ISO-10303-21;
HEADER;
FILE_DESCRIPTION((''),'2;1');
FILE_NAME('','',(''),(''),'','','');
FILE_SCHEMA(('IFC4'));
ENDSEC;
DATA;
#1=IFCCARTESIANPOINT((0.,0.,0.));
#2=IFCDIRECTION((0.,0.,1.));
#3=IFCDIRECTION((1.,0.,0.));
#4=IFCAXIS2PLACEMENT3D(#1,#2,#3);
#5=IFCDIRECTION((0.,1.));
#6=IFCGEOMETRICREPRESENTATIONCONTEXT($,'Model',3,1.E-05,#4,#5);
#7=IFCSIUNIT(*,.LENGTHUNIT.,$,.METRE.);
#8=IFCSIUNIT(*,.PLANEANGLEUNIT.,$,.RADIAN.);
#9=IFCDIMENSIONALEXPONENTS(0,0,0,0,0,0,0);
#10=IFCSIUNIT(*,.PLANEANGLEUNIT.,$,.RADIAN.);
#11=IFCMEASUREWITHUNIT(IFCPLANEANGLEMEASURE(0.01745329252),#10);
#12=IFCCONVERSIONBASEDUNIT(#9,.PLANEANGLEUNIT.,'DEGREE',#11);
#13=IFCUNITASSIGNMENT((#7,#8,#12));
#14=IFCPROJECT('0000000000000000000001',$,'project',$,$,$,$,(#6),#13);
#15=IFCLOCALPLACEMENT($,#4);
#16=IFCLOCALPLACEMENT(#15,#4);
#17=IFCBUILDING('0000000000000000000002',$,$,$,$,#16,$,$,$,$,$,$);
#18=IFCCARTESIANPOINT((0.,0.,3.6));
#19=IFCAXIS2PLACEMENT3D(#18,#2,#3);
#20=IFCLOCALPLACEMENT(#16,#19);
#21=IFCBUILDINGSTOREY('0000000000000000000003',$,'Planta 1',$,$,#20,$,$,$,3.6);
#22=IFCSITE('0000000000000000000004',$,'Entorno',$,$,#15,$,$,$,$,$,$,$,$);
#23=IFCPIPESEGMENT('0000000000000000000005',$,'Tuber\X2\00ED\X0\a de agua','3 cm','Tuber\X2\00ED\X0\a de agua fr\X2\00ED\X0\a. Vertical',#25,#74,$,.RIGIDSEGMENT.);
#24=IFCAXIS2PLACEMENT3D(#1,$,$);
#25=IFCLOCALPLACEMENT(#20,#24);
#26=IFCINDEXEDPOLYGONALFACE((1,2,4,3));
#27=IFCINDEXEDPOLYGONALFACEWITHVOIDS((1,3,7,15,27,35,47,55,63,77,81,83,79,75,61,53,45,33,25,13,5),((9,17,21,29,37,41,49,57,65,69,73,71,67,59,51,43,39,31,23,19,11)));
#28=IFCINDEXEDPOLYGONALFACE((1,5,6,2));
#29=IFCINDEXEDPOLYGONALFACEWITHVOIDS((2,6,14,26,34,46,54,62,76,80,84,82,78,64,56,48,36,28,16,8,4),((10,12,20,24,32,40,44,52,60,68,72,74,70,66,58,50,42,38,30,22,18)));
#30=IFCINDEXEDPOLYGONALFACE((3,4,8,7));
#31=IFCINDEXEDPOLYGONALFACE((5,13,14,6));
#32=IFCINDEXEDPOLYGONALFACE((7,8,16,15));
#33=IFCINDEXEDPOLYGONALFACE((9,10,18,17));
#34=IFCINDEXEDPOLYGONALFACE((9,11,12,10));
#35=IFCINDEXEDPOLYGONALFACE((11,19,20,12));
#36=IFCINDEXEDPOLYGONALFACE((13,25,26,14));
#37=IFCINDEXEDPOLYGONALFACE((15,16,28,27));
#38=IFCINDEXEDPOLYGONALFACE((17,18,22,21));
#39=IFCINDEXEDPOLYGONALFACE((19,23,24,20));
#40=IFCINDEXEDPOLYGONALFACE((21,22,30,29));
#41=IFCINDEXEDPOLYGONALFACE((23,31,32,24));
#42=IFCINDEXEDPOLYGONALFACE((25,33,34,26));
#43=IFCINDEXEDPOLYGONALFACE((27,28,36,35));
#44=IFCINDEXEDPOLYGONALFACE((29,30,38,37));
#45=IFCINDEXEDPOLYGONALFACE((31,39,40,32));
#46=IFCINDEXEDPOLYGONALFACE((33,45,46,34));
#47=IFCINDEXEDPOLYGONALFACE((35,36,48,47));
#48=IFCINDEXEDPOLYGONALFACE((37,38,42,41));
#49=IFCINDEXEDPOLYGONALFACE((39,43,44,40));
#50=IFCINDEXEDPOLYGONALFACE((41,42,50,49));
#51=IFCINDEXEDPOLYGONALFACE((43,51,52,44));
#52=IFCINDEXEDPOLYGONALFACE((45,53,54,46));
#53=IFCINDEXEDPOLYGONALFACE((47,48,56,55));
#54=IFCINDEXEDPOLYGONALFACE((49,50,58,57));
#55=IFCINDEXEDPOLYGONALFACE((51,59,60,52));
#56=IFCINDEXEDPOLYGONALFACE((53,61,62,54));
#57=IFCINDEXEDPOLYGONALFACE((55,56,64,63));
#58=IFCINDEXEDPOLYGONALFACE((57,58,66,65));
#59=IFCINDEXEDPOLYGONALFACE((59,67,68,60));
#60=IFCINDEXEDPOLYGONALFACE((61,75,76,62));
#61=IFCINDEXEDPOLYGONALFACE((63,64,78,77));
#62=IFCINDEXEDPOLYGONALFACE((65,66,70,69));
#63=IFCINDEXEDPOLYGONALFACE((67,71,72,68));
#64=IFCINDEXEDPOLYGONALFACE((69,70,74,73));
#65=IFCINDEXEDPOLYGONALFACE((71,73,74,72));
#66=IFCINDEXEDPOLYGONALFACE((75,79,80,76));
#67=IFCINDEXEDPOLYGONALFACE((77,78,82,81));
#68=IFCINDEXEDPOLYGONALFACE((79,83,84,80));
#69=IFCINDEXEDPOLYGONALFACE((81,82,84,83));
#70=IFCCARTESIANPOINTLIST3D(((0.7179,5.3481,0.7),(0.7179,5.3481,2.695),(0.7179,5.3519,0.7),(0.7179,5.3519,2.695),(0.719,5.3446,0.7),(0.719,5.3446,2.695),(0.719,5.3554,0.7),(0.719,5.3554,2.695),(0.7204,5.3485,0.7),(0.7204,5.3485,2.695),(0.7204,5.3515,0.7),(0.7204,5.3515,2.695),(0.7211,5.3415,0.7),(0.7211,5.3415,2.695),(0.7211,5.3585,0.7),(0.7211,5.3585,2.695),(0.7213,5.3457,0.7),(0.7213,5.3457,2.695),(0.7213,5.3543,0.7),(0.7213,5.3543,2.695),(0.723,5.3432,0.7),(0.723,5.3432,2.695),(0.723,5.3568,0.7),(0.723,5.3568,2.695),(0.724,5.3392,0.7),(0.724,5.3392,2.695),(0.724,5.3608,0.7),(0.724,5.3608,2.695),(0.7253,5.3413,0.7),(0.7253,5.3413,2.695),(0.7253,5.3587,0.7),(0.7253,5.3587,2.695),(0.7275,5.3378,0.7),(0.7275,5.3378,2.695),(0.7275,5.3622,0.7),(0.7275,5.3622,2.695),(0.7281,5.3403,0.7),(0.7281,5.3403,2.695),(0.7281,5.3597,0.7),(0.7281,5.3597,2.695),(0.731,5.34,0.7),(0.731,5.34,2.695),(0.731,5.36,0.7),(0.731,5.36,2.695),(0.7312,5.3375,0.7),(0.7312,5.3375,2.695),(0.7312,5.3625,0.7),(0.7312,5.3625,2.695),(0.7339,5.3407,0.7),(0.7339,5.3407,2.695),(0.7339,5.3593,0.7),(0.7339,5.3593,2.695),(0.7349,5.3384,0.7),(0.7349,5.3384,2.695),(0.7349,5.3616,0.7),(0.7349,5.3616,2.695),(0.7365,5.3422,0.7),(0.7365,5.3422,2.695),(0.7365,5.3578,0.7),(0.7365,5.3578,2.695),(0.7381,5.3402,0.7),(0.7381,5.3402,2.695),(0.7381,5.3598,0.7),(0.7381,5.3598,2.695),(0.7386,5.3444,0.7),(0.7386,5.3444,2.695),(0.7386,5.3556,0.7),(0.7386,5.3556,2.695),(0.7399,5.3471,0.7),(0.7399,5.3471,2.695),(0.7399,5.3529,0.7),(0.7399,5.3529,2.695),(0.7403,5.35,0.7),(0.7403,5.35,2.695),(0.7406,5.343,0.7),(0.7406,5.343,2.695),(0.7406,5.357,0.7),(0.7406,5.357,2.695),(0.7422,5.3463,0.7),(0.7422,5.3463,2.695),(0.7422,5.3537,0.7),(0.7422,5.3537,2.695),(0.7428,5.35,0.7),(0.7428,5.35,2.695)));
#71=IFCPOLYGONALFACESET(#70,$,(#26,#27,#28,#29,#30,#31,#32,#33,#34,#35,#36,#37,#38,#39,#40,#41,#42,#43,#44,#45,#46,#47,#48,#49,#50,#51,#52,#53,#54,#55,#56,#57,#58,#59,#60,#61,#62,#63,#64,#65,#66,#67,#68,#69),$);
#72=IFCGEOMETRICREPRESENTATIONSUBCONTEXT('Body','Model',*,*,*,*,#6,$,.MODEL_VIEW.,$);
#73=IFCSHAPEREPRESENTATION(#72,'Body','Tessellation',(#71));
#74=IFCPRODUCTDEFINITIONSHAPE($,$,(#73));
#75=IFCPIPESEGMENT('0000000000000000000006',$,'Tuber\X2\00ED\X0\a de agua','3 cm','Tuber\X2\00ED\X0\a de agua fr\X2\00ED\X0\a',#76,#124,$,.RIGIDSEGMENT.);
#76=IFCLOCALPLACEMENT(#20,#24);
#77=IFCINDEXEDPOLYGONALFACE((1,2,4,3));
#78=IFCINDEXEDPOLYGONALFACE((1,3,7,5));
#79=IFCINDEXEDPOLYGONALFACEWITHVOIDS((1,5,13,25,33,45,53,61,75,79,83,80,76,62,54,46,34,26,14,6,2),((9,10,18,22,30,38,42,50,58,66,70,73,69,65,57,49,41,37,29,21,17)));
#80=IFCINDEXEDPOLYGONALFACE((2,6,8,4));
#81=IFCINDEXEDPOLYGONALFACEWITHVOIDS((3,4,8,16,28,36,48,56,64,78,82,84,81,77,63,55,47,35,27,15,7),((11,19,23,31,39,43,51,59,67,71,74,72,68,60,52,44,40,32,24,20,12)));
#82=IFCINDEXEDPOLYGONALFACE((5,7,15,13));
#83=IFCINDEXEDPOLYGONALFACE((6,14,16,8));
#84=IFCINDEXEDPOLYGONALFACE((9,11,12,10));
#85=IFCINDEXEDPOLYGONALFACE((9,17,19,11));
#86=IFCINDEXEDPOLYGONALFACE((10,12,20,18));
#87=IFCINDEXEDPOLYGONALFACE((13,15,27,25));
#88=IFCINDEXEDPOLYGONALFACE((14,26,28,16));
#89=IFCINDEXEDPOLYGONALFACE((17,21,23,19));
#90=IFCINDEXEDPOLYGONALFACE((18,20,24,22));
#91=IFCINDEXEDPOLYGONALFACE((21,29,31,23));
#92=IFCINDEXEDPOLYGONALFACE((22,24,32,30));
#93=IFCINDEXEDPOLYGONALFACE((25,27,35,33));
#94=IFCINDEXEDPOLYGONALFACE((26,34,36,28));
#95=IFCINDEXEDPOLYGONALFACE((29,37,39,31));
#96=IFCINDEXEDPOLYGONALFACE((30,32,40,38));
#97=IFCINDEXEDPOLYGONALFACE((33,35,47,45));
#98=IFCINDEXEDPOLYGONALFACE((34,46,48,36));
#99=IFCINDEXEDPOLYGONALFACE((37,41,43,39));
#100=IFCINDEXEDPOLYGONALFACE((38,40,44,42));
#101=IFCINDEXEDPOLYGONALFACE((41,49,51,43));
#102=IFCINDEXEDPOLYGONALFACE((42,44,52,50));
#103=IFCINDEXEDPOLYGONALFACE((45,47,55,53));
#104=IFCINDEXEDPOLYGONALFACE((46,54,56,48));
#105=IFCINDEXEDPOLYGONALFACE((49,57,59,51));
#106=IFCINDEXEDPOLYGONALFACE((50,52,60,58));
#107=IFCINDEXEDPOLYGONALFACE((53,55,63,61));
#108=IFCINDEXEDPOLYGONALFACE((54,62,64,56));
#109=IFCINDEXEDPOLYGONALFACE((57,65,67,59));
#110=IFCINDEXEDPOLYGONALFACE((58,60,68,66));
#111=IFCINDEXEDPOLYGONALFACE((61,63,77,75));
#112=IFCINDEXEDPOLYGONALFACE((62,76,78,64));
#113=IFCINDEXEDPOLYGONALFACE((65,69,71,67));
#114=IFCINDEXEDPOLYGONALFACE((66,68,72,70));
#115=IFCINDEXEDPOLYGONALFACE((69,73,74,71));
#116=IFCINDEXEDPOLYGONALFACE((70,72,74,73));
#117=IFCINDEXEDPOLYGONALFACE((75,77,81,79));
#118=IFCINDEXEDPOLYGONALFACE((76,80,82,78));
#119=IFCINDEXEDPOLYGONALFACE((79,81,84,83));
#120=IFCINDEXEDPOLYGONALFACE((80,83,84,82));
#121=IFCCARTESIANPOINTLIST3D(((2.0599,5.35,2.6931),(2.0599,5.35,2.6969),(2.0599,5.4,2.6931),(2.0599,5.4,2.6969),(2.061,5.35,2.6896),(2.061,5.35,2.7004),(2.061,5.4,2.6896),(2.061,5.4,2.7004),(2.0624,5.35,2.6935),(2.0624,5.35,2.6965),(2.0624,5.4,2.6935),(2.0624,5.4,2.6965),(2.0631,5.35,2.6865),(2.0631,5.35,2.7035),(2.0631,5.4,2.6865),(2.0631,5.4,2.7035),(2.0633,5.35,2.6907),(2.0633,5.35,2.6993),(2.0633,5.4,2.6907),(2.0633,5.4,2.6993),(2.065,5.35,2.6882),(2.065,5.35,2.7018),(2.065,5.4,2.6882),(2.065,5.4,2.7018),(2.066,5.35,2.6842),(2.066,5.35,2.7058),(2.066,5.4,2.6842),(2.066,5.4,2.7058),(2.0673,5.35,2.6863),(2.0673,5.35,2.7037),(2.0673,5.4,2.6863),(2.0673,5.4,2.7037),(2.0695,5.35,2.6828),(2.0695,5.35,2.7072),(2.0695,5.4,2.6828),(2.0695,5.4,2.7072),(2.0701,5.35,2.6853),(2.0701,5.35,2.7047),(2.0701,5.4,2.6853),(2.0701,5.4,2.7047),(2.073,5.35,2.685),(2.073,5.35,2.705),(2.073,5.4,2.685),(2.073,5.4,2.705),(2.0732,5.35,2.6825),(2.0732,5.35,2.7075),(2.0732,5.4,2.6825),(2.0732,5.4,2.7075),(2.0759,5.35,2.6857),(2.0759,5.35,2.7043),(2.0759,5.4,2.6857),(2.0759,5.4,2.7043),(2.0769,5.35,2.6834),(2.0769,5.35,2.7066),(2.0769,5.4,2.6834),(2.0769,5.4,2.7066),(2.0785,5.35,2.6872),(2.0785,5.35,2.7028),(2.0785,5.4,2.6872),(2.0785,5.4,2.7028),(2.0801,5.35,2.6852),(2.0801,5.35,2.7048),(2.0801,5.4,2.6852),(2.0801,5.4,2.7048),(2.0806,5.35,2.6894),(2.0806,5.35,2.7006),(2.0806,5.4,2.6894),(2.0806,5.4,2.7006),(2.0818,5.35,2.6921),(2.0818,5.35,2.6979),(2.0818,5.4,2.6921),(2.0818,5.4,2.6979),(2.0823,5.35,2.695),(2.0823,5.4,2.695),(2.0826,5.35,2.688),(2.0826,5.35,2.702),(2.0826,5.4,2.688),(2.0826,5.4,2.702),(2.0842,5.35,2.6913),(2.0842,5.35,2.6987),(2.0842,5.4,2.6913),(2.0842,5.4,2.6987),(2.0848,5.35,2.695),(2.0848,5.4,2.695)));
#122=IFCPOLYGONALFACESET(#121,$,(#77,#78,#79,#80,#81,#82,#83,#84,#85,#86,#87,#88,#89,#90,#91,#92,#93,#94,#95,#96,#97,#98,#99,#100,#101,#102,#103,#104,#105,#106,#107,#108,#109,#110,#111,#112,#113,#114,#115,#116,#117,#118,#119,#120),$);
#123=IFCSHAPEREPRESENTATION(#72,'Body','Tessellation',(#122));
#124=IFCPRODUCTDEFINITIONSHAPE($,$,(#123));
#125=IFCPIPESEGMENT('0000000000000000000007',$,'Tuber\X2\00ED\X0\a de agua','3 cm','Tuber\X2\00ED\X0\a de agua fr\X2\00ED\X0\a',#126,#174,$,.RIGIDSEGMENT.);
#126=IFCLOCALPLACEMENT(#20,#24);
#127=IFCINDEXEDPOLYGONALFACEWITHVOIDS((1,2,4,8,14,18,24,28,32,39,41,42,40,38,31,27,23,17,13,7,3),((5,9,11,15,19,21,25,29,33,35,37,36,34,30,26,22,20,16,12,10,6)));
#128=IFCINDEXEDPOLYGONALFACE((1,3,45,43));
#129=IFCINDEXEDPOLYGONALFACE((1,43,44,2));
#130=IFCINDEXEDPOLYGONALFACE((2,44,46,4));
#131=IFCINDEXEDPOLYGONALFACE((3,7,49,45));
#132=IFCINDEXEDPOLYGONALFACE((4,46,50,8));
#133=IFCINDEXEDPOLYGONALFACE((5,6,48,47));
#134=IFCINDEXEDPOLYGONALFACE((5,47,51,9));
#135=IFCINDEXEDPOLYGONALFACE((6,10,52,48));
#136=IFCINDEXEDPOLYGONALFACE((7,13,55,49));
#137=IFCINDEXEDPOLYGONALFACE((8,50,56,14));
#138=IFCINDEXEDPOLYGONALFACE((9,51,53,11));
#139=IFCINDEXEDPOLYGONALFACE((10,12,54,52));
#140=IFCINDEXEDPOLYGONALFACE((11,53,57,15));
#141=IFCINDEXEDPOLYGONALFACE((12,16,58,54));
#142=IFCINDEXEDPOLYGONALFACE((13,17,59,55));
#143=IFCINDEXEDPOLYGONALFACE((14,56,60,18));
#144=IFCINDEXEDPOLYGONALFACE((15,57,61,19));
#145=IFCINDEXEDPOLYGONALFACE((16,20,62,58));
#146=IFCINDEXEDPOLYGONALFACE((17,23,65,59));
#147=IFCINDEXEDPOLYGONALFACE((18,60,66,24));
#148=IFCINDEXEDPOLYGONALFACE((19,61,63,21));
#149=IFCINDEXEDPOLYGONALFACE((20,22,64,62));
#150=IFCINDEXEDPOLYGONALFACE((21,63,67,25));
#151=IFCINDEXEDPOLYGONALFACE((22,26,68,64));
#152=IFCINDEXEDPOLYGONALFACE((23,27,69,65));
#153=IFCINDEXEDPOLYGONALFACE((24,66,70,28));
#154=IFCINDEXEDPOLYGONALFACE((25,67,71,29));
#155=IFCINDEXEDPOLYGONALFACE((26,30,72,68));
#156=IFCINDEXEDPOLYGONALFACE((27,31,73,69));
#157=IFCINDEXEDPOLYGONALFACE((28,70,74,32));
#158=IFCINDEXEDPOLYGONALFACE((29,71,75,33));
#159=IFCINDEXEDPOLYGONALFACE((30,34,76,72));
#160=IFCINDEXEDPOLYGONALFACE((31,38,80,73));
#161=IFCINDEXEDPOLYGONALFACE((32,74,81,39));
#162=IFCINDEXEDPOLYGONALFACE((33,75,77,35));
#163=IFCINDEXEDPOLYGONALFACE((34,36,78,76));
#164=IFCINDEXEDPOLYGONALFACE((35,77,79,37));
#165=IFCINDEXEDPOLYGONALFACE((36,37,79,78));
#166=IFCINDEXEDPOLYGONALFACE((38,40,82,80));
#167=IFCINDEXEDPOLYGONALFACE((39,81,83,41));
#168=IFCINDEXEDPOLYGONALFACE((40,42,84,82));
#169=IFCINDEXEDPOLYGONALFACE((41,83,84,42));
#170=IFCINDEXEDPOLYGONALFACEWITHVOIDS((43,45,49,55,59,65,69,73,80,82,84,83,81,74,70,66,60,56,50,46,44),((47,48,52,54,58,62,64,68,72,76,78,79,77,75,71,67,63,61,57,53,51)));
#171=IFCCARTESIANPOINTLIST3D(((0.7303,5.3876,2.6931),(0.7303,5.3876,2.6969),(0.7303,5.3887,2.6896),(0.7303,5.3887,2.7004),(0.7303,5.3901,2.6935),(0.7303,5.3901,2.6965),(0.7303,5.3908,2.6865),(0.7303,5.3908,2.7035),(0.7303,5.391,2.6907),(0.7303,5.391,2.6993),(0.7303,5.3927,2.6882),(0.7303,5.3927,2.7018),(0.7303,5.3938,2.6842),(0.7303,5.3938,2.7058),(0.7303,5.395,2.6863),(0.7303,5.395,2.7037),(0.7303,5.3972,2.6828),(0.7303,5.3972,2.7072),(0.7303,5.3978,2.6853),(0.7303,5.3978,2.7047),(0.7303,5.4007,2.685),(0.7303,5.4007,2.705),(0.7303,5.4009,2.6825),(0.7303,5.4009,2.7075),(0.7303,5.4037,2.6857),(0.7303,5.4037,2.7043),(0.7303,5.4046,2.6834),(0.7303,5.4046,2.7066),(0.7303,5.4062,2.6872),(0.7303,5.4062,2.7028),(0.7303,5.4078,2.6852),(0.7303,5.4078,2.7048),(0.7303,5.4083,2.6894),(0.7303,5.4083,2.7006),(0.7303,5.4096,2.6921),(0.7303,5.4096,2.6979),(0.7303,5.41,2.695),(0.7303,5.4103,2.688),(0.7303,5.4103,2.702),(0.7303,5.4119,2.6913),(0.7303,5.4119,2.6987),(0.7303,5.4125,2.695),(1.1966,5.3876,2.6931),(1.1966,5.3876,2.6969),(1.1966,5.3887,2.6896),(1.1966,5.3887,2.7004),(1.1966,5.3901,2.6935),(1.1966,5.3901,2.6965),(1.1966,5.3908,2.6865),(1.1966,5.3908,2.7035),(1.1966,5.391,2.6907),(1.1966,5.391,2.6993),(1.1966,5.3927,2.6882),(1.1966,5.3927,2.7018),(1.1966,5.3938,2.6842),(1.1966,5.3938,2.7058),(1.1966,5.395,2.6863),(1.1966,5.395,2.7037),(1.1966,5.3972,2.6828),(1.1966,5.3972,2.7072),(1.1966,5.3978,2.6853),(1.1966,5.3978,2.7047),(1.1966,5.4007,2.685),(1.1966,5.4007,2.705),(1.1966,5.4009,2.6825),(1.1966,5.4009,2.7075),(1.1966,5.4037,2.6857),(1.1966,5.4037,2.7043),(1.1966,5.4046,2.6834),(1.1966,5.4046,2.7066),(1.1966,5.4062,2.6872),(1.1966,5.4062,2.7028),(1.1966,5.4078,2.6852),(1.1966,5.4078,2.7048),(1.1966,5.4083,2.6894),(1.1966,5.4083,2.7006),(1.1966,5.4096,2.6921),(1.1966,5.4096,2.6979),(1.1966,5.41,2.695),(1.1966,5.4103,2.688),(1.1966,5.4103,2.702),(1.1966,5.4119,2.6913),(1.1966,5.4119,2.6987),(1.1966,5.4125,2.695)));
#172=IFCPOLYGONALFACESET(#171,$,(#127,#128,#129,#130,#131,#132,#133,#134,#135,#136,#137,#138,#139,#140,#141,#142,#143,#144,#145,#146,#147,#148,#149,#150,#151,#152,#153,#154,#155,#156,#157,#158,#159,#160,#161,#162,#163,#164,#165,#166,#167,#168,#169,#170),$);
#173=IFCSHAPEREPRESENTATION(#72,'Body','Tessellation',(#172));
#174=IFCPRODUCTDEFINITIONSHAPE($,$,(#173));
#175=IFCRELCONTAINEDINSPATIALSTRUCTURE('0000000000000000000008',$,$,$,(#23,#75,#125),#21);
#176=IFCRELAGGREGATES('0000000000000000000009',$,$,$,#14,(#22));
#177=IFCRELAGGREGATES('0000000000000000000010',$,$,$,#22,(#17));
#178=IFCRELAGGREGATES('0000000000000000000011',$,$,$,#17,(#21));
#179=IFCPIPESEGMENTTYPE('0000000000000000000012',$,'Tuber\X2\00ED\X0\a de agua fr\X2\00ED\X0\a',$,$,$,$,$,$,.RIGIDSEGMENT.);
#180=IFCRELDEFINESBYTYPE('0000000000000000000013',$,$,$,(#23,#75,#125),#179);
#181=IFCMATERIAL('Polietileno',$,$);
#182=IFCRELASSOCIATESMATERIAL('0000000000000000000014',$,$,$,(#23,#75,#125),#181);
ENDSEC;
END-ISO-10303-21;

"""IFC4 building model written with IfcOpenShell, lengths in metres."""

from ifc_helpers import new_model, entity, si_unit, converted_unit, direction, frame, origin_with_axes, origin_2d_with_axis, place, context, subcontext, project, spatial, hollow_circle, extrude, material, type_object, element, save


model = new_model("IFC4")

# Units and contexts
model_context = context("Model", 3, precision=1e-05, world=origin_with_axes(), true_north=direction((0.0, 1.0)))
body_context = subcontext(model_context, "Body", "Model", "MODEL_VIEW")
ifc_project = project(units=[si_unit("LENGTHUNIT", "METRE"), si_unit("PLANEANGLEUNIT", "RADIAN"), converted_unit("PLANEANGLEUNIT", "DEGREE", entity("IfcPlaneAngleMeasure", 0.01745329252), si_unit("PLANEANGLEUNIT", "RADIAN"), dimensions=[0, 0, 0, 0, 0, 0, 0])], contexts=[model_context])

# Site, building, storey
site_placement = place(None, origin_with_axes())
site = spatial("IfcSite", under=ifc_project, at=site_placement, Name="Entorno")
building_placement = place(site_placement, origin_with_axes())
building = spatial("IfcBuilding", under=site, at=building_placement)
storey_placement = place(building_placement, frame((0.0, 0.0, 3.6), z_axis=(0.0, 0.0, 1.0), x_axis=(1.0, 0.0, 0.0)))
storey = spatial("IfcBuildingStorey", under=building, at=storey_placement, Name="Planta 1", Elevation=3.6)

# Pipe segments
ifc_material_1 = material(Name="Polietileno")
pipe_segment_type_1 = type_object("IfcPipeSegmentType", Name="Tubería de agua fría", PredefinedType="RIGIDSEGMENT")
pipe_segment_1_placement = place(storey_placement, frame((0.7303, 5.35, 2.695), z_axis=(0.0, 0.0, -1.0), x_axis=(1.0, 0.0, 0.0)))
element("IfcPipeSegment", 1, at=pipe_segment_1_placement, inside=storey, type_object=pipe_segment_type_1, material=ifc_material_1, Name="Tubería de agua", Description="3 cm", ObjectType="Tubería de agua fría. Vertical", PredefinedType="RIGIDSEGMENT", context=body_context, shape_type="SweptSolid", body=[
    extrude(hollow_circle(Radius=0.0125, WallThickness=0.0025, at=origin_2d_with_axis()), origin_with_axes(), (0.0, 0.0, 1.0), 1.995),
])
pipe_segment_2_placement = place(storey_placement, frame((2.0723, 5.4, 2.695), z_axis=(0.0, -1.0, 0.0), x_axis=(1.0, 0.0, 0.0)))
element("IfcPipeSegment", 2, at=pipe_segment_2_placement, inside=storey, type_object=pipe_segment_type_1, material=ifc_material_1, Name="Tubería de agua", Description="3 cm", ObjectType="Tubería de agua fría", PredefinedType="RIGIDSEGMENT", context=body_context, shape_type="SweptSolid", body=[
    extrude(hollow_circle(Radius=0.0125, WallThickness=0.0025, at=origin_2d_with_axis()), origin_with_axes(), (0.0, 0.0, 1.0), 0.05),
])
pipe_segment_3_placement = place(storey_placement, frame((0.7303, 5.4, 2.695), z_axis=(1.0, 0.0, 0.0), x_axis=(0.0, 1.0, 0.0)))
element("IfcPipeSegment", 3, at=pipe_segment_3_placement, inside=storey, type_object=pipe_segment_type_1, material=ifc_material_1, Name="Tubería de agua", Description="3 cm", ObjectType="Tubería de agua fría", PredefinedType="RIGIDSEGMENT", context=body_context, shape_type="SweptSolid", body=[
    extrude(hollow_circle(Radius=0.0125, WallThickness=0.0025, at=origin_2d_with_axis()), origin_with_axes(), (0.0, 0.0, 1.0), 0.4663),
])

save(model, "model.ifc")
